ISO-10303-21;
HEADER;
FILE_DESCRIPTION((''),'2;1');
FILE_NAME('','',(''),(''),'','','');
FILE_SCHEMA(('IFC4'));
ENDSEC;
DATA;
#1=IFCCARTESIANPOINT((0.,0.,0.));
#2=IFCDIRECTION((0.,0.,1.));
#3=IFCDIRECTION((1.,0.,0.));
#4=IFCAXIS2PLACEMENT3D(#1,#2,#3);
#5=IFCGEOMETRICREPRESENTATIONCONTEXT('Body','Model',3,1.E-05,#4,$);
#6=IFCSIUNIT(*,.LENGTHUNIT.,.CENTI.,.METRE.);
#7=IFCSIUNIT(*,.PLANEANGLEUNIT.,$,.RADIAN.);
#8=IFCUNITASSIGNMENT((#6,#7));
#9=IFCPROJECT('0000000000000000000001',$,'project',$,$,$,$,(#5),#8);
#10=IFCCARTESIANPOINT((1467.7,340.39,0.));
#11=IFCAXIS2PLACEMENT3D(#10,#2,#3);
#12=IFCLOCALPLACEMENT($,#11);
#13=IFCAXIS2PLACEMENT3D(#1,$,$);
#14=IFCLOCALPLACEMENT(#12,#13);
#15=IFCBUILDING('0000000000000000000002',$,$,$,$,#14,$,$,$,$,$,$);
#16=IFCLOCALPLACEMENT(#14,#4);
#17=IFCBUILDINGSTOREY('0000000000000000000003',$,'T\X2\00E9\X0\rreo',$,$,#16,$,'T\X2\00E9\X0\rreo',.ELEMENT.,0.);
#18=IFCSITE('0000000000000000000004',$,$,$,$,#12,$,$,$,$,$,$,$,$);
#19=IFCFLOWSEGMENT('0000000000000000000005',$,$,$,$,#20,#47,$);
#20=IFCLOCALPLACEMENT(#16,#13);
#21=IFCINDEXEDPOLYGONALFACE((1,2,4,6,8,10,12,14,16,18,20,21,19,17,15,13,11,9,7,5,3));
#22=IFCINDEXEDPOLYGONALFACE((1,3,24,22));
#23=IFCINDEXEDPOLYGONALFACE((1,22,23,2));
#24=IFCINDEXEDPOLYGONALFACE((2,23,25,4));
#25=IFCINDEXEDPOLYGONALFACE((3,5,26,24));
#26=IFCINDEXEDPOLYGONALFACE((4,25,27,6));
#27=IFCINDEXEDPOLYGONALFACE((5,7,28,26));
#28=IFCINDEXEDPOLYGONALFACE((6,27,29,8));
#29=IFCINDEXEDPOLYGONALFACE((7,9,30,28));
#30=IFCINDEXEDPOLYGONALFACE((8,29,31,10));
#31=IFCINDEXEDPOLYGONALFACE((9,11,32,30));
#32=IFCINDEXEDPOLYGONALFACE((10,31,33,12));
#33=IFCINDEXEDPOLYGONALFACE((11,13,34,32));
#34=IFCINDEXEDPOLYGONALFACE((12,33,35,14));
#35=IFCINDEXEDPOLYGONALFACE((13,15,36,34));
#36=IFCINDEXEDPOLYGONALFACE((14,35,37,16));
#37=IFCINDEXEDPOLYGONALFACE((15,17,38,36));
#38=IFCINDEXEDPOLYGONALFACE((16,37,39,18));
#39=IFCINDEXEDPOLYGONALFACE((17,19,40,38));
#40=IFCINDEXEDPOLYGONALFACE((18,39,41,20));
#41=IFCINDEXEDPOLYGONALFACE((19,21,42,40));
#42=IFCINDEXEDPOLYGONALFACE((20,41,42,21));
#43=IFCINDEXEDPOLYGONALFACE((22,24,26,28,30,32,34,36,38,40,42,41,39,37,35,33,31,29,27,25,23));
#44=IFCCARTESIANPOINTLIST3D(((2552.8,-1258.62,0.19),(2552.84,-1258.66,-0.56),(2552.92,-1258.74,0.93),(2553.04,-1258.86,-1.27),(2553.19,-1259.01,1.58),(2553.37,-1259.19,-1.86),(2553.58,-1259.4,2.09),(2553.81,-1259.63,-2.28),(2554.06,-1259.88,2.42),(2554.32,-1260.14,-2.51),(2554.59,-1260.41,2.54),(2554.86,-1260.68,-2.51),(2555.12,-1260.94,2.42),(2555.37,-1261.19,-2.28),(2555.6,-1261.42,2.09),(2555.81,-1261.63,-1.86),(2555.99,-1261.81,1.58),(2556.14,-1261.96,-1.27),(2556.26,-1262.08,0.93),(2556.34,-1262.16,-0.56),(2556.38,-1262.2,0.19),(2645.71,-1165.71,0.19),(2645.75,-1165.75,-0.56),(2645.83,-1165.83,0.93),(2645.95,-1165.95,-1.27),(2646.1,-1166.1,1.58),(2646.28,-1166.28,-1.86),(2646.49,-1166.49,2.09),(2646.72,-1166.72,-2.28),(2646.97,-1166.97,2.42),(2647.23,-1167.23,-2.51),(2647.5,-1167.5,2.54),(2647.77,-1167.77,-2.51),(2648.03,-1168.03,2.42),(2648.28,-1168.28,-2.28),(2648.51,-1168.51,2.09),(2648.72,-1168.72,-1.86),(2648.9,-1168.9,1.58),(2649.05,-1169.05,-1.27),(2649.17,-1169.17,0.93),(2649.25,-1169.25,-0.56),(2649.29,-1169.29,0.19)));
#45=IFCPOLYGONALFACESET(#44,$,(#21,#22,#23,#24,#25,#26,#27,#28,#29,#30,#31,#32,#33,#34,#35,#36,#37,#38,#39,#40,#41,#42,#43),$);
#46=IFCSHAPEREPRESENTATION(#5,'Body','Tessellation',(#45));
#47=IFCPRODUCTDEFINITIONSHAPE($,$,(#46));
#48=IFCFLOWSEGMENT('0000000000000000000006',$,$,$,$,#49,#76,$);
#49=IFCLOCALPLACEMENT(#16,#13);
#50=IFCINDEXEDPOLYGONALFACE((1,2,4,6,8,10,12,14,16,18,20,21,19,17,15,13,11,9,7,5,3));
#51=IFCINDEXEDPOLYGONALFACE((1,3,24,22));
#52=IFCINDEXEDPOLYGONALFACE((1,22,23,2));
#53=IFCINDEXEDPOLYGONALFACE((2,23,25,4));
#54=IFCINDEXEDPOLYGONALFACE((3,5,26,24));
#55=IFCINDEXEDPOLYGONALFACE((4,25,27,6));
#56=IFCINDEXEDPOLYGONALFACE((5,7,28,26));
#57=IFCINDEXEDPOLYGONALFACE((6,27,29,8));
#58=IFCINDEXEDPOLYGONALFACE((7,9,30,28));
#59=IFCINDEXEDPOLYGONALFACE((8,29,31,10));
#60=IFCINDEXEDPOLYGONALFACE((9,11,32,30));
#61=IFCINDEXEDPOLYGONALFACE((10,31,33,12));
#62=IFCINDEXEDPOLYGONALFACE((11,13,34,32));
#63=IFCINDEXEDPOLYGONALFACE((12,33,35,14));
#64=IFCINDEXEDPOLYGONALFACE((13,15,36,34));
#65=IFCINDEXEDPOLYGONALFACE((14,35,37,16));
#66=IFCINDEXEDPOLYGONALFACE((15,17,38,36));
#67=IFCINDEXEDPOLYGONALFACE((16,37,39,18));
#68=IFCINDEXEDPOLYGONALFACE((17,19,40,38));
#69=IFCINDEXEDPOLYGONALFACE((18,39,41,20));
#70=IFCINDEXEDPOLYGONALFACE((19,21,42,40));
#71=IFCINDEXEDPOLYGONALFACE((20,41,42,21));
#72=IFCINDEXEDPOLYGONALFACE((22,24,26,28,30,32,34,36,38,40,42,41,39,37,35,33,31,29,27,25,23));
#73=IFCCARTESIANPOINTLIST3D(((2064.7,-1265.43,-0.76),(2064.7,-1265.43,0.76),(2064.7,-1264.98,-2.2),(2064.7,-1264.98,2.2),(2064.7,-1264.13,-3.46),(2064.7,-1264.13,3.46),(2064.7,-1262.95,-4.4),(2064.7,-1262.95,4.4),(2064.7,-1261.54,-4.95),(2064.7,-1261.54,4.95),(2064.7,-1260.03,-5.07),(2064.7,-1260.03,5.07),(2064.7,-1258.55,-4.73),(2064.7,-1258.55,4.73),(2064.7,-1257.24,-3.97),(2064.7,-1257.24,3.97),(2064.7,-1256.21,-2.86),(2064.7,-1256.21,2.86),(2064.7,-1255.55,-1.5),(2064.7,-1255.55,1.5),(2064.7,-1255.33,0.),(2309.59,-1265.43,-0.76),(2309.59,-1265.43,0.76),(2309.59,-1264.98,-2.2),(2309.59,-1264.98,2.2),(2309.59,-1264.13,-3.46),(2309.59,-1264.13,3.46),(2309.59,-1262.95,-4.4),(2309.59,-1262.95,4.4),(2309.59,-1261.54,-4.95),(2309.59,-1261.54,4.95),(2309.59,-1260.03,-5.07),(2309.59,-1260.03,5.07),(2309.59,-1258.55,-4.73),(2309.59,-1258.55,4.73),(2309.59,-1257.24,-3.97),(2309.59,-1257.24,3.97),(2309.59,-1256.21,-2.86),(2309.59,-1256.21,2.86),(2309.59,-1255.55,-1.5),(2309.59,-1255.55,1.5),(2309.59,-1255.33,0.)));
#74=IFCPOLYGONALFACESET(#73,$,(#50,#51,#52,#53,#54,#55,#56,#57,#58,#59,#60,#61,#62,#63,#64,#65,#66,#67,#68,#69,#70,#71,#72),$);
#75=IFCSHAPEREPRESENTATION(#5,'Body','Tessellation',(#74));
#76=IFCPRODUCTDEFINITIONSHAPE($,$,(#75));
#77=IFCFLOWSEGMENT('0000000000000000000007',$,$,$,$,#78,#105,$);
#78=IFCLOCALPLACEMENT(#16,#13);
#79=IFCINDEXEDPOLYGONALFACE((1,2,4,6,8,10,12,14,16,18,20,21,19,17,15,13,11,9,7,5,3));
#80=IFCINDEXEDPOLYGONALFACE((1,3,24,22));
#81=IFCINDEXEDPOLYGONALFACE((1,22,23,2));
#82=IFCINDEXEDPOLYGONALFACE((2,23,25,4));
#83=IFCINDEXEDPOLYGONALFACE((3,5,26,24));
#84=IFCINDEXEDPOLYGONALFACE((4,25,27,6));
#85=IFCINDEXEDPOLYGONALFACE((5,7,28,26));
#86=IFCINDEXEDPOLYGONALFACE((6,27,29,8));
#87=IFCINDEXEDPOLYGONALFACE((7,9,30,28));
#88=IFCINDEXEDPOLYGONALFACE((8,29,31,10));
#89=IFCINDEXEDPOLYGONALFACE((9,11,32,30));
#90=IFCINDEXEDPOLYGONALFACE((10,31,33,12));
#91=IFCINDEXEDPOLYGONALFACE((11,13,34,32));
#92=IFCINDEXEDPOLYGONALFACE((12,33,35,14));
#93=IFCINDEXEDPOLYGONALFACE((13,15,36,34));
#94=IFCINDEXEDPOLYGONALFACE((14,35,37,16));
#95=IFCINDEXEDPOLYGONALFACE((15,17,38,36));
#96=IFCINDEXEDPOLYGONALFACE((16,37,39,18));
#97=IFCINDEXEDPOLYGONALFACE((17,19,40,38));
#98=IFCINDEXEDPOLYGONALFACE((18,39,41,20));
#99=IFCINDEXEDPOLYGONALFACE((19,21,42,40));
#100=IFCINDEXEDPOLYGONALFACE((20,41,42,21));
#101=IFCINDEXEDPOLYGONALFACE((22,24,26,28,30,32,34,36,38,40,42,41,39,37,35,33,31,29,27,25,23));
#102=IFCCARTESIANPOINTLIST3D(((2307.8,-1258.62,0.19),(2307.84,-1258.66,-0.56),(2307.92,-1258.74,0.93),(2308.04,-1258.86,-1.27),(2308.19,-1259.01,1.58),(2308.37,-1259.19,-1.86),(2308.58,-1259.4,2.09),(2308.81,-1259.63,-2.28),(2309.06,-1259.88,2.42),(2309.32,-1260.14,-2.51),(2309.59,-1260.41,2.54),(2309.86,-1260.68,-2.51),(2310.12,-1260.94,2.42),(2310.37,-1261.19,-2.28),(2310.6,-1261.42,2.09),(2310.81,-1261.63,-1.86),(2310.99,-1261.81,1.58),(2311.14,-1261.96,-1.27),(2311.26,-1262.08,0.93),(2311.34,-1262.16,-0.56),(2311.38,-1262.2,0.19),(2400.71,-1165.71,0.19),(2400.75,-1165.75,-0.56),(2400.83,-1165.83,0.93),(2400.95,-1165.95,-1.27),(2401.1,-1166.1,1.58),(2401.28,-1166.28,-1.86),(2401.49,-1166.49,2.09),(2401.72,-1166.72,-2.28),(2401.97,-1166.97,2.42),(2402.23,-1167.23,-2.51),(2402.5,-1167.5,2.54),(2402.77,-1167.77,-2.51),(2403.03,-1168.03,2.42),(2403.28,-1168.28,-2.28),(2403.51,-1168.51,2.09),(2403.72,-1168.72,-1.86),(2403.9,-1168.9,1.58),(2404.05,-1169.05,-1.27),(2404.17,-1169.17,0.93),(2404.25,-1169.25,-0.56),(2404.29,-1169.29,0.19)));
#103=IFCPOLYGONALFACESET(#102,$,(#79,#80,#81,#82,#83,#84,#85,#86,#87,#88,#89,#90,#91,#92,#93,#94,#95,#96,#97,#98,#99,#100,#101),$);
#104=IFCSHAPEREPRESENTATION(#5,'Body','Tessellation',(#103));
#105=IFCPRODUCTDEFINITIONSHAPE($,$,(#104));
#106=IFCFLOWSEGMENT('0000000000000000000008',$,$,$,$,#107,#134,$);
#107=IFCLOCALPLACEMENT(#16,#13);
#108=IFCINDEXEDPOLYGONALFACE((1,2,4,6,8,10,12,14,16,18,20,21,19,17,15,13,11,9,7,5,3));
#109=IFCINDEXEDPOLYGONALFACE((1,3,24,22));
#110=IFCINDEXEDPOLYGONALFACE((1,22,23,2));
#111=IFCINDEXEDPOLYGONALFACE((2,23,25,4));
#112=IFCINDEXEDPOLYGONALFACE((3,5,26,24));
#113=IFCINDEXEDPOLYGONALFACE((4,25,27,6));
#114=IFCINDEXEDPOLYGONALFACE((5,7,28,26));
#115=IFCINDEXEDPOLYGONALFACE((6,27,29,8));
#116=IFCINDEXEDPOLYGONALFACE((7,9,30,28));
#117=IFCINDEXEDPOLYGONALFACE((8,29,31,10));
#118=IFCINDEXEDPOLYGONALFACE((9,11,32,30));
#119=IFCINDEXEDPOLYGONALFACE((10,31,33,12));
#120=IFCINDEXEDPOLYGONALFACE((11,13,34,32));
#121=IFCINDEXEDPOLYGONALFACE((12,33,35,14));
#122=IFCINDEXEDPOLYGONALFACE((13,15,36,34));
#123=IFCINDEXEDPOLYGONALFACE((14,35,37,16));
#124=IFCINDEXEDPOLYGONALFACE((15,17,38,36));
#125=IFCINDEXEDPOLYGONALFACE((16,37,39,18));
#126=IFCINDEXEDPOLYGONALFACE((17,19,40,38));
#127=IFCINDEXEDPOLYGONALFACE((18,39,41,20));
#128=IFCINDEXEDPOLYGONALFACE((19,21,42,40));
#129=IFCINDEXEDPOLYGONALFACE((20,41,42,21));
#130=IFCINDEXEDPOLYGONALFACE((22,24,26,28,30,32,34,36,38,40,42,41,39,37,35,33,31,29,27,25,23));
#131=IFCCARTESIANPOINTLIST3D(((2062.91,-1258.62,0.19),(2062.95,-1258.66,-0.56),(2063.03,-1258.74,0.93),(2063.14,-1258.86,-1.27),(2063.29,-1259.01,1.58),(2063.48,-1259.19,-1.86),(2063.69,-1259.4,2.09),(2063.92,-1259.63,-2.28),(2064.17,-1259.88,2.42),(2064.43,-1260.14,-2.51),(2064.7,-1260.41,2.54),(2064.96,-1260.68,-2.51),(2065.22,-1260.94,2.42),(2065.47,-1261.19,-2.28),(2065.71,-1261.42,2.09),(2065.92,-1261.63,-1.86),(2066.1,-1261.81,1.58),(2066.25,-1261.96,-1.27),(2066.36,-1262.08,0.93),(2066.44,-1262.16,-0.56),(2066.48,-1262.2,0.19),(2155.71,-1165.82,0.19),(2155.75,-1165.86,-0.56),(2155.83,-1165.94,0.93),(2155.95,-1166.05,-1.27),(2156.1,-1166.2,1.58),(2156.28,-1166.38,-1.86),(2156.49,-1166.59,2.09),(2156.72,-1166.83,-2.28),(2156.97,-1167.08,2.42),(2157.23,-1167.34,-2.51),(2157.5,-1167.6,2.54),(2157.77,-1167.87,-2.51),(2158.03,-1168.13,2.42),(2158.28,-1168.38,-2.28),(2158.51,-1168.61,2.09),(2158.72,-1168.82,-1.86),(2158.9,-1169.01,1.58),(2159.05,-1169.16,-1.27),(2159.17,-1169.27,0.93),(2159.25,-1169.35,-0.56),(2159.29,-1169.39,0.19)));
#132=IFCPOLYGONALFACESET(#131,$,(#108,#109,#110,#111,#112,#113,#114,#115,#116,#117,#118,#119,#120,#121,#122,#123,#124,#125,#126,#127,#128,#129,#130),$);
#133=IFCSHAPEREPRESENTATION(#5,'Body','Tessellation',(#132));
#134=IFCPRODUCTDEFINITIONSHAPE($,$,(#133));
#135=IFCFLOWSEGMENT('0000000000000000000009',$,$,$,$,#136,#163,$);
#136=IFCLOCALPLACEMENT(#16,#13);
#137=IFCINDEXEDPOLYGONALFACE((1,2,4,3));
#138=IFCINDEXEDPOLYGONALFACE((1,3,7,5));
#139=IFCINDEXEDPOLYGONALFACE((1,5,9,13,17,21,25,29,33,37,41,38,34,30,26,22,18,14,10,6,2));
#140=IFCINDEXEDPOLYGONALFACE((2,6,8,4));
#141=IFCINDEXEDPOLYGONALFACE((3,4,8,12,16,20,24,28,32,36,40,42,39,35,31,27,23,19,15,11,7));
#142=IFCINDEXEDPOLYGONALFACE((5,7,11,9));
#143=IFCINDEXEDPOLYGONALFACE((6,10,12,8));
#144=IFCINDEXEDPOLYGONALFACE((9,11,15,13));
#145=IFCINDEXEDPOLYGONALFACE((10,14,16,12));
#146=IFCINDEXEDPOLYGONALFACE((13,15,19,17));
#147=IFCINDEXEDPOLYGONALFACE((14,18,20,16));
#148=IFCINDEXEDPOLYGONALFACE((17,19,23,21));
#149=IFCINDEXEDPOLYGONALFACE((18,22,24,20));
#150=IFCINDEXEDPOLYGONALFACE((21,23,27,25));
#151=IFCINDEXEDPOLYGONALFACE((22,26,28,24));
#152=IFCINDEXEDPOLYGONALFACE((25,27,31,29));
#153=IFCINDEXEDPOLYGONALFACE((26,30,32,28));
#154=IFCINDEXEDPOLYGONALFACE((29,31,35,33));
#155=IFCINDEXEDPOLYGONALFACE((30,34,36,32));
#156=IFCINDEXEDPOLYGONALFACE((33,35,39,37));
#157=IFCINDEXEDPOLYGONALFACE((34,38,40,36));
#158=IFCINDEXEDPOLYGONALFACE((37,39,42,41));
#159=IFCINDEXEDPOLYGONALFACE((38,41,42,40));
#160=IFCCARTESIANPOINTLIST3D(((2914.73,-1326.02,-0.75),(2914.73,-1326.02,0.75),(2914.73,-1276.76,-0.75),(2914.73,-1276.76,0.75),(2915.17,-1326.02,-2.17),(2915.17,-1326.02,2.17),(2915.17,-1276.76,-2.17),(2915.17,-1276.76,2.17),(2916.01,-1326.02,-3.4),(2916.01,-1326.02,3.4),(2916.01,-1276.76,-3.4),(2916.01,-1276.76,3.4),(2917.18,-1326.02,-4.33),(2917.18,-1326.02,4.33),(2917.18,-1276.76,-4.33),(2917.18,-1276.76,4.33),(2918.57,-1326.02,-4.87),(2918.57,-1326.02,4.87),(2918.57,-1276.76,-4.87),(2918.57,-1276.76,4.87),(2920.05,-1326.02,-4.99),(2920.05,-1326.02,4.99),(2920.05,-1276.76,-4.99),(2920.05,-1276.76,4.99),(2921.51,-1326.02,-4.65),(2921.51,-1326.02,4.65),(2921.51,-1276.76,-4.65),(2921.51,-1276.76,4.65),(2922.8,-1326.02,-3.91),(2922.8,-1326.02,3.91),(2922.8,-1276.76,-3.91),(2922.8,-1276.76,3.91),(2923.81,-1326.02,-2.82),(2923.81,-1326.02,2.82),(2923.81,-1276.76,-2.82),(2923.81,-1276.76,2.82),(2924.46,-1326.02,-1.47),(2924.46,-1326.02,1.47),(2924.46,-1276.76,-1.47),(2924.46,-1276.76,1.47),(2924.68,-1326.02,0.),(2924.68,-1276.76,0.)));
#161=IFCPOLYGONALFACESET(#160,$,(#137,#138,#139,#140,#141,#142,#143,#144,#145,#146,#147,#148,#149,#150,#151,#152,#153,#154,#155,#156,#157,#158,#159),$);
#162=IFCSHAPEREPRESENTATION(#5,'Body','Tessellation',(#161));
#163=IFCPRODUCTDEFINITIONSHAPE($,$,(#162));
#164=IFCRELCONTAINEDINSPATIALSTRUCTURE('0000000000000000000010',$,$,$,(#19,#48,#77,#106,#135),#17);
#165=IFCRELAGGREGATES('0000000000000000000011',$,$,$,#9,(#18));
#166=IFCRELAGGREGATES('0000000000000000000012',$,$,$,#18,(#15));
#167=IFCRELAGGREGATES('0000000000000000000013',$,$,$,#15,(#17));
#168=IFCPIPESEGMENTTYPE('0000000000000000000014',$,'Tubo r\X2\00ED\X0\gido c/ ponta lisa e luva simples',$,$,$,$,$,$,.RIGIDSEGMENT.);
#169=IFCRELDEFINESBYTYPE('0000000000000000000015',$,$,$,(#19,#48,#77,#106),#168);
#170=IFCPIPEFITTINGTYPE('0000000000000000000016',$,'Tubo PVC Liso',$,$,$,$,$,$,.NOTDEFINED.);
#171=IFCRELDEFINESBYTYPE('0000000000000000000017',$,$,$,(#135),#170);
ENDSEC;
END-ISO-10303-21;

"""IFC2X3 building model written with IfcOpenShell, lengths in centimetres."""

from ifc_helpers import new_model, si_unit, frame, origin, origin_with_axes, origin_2d_with_axis, place, context, project, spatial, circle, extrude, type_object, element, save


model = new_model("IFC2X3")

# Units and contexts
model_context = context("Model", 3, precision=1e-05, world=origin_with_axes(), identifier="Body")
ifc_project = project(units=[si_unit("LENGTHUNIT", "METRE", prefix="CENTI"), si_unit("PLANEANGLEUNIT", "RADIAN")], contexts=[model_context])

# Site, building, storey
site_placement = place(None, frame((1467.7, 340.39, 0.0), z_axis=(0.0, 0.0, 1.0), x_axis=(1.0, 0.0, 0.0)))
site = spatial("IfcSite", under=ifc_project, at=site_placement)
building_placement = place(site_placement, origin())
building = spatial("IfcBuilding", under=site, at=building_placement)
storey_placement = place(building_placement, origin_with_axes())
storey = spatial("IfcBuildingStorey", under=building, at=storey_placement, Name="Térreo", LongName="Térreo", CompositionType="ELEMENT", Elevation=0.0)

# Flow segments
pipe_segment_type_1 = type_object("IfcPipeSegmentType", Name="Tubo rígido c/ ponta lisa e luva simples", PredefinedType="RIGIDSEGMENT")
flow_segment_1_placement = place(storey_placement, frame((2601.05, -1213.95, 2.54), z_axis=(0.0, 0.0, 1.0), x_axis=(1.0, 0.0, 0.0)))
element("IfcFlowSegment", 1, at=flow_segment_1_placement, inside=storey, type_object=pipe_segment_type_1, context=model_context, shape_type="SolidModel", body=[
    extrude(circle(Radius=2.54, at=origin_2d_with_axis()), frame((46.45, 46.45, -2.54), z_axis=(-0.707107, -0.707107, 0.0), x_axis=(0.0, 0.0, 1.0)), (0.0, 0.0, 1.0), 131.39),
])
flow_segment_2_placement = place(storey_placement, frame((2187.14, -1260.41, 5.08), z_axis=(0.0, 0.0, 1.0), x_axis=(1.0, 0.0, 0.0)))
element("IfcFlowSegment", 2, at=flow_segment_2_placement, inside=storey, type_object=pipe_segment_type_1, context=model_context, shape_type="SolidModel", body=[
    extrude(circle(Radius=5.08, at=origin_2d_with_axis()), frame((122.45, 0.0, -5.08), z_axis=(-1.0, 0.0, 0.0), x_axis=(0.0, 1.0, 0.0)), (0.0, 0.0, 1.0), 244.9),
])
flow_segment_3_placement = place(storey_placement, frame((2356.05, -1213.95, 2.54), z_axis=(0.0, 0.0, 1.0), x_axis=(1.0, 0.0, 0.0)))
element("IfcFlowSegment", 3, at=flow_segment_3_placement, inside=storey, type_object=pipe_segment_type_1, context=model_context, shape_type="SolidModel", body=[
    extrude(circle(Radius=2.54, at=origin_2d_with_axis()), frame((46.45, 46.45, -2.54), z_axis=(-0.707107, -0.707107, 0.0), x_axis=(0.0, 0.0, 1.0)), (0.0, 0.0, 1.0), 131.39),
])
flow_segment_4_placement = place(storey_placement, frame((2111.1, -1214.01, 2.54), z_axis=(0.0, 0.0, 1.0), x_axis=(1.0, 0.0, 0.0)))
element("IfcFlowSegment", 4, at=flow_segment_4_placement, inside=storey, type_object=pipe_segment_type_1, context=model_context, shape_type="SolidModel", body=[
    extrude(circle(Radius=2.54, at=origin_2d_with_axis()), frame((46.4, 46.4, -2.54), z_axis=(-0.707107, -0.707107, 0.0), x_axis=(0.0, 0.0, 1.0)), (0.0, 0.0, 1.0), 131.24),
])
pipe_fitting_type = type_object("IfcPipeFittingType", Name="Tubo PVC Liso", PredefinedType="NOTDEFINED")
flow_segment_5_placement = place(storey_placement, frame((2919.68, -1301.39, 5.0), z_axis=(0.0, 0.0, 1.0), x_axis=(1.0, 0.0, 0.0)))
element("IfcFlowSegment", 5, at=flow_segment_5_placement, inside=storey, type_object=pipe_fitting_type, context=model_context, shape_type="SolidModel", body=[
    extrude(circle(Radius=5.0, at=origin_2d_with_axis()), frame((0.0, 24.63, -5.0), z_axis=(0.0, -1.0, 0.0), x_axis=(1.0, 0.0, 0.0)), (0.0, 0.0, 1.0), 49.26),
])

save(model, "model.ifc")
